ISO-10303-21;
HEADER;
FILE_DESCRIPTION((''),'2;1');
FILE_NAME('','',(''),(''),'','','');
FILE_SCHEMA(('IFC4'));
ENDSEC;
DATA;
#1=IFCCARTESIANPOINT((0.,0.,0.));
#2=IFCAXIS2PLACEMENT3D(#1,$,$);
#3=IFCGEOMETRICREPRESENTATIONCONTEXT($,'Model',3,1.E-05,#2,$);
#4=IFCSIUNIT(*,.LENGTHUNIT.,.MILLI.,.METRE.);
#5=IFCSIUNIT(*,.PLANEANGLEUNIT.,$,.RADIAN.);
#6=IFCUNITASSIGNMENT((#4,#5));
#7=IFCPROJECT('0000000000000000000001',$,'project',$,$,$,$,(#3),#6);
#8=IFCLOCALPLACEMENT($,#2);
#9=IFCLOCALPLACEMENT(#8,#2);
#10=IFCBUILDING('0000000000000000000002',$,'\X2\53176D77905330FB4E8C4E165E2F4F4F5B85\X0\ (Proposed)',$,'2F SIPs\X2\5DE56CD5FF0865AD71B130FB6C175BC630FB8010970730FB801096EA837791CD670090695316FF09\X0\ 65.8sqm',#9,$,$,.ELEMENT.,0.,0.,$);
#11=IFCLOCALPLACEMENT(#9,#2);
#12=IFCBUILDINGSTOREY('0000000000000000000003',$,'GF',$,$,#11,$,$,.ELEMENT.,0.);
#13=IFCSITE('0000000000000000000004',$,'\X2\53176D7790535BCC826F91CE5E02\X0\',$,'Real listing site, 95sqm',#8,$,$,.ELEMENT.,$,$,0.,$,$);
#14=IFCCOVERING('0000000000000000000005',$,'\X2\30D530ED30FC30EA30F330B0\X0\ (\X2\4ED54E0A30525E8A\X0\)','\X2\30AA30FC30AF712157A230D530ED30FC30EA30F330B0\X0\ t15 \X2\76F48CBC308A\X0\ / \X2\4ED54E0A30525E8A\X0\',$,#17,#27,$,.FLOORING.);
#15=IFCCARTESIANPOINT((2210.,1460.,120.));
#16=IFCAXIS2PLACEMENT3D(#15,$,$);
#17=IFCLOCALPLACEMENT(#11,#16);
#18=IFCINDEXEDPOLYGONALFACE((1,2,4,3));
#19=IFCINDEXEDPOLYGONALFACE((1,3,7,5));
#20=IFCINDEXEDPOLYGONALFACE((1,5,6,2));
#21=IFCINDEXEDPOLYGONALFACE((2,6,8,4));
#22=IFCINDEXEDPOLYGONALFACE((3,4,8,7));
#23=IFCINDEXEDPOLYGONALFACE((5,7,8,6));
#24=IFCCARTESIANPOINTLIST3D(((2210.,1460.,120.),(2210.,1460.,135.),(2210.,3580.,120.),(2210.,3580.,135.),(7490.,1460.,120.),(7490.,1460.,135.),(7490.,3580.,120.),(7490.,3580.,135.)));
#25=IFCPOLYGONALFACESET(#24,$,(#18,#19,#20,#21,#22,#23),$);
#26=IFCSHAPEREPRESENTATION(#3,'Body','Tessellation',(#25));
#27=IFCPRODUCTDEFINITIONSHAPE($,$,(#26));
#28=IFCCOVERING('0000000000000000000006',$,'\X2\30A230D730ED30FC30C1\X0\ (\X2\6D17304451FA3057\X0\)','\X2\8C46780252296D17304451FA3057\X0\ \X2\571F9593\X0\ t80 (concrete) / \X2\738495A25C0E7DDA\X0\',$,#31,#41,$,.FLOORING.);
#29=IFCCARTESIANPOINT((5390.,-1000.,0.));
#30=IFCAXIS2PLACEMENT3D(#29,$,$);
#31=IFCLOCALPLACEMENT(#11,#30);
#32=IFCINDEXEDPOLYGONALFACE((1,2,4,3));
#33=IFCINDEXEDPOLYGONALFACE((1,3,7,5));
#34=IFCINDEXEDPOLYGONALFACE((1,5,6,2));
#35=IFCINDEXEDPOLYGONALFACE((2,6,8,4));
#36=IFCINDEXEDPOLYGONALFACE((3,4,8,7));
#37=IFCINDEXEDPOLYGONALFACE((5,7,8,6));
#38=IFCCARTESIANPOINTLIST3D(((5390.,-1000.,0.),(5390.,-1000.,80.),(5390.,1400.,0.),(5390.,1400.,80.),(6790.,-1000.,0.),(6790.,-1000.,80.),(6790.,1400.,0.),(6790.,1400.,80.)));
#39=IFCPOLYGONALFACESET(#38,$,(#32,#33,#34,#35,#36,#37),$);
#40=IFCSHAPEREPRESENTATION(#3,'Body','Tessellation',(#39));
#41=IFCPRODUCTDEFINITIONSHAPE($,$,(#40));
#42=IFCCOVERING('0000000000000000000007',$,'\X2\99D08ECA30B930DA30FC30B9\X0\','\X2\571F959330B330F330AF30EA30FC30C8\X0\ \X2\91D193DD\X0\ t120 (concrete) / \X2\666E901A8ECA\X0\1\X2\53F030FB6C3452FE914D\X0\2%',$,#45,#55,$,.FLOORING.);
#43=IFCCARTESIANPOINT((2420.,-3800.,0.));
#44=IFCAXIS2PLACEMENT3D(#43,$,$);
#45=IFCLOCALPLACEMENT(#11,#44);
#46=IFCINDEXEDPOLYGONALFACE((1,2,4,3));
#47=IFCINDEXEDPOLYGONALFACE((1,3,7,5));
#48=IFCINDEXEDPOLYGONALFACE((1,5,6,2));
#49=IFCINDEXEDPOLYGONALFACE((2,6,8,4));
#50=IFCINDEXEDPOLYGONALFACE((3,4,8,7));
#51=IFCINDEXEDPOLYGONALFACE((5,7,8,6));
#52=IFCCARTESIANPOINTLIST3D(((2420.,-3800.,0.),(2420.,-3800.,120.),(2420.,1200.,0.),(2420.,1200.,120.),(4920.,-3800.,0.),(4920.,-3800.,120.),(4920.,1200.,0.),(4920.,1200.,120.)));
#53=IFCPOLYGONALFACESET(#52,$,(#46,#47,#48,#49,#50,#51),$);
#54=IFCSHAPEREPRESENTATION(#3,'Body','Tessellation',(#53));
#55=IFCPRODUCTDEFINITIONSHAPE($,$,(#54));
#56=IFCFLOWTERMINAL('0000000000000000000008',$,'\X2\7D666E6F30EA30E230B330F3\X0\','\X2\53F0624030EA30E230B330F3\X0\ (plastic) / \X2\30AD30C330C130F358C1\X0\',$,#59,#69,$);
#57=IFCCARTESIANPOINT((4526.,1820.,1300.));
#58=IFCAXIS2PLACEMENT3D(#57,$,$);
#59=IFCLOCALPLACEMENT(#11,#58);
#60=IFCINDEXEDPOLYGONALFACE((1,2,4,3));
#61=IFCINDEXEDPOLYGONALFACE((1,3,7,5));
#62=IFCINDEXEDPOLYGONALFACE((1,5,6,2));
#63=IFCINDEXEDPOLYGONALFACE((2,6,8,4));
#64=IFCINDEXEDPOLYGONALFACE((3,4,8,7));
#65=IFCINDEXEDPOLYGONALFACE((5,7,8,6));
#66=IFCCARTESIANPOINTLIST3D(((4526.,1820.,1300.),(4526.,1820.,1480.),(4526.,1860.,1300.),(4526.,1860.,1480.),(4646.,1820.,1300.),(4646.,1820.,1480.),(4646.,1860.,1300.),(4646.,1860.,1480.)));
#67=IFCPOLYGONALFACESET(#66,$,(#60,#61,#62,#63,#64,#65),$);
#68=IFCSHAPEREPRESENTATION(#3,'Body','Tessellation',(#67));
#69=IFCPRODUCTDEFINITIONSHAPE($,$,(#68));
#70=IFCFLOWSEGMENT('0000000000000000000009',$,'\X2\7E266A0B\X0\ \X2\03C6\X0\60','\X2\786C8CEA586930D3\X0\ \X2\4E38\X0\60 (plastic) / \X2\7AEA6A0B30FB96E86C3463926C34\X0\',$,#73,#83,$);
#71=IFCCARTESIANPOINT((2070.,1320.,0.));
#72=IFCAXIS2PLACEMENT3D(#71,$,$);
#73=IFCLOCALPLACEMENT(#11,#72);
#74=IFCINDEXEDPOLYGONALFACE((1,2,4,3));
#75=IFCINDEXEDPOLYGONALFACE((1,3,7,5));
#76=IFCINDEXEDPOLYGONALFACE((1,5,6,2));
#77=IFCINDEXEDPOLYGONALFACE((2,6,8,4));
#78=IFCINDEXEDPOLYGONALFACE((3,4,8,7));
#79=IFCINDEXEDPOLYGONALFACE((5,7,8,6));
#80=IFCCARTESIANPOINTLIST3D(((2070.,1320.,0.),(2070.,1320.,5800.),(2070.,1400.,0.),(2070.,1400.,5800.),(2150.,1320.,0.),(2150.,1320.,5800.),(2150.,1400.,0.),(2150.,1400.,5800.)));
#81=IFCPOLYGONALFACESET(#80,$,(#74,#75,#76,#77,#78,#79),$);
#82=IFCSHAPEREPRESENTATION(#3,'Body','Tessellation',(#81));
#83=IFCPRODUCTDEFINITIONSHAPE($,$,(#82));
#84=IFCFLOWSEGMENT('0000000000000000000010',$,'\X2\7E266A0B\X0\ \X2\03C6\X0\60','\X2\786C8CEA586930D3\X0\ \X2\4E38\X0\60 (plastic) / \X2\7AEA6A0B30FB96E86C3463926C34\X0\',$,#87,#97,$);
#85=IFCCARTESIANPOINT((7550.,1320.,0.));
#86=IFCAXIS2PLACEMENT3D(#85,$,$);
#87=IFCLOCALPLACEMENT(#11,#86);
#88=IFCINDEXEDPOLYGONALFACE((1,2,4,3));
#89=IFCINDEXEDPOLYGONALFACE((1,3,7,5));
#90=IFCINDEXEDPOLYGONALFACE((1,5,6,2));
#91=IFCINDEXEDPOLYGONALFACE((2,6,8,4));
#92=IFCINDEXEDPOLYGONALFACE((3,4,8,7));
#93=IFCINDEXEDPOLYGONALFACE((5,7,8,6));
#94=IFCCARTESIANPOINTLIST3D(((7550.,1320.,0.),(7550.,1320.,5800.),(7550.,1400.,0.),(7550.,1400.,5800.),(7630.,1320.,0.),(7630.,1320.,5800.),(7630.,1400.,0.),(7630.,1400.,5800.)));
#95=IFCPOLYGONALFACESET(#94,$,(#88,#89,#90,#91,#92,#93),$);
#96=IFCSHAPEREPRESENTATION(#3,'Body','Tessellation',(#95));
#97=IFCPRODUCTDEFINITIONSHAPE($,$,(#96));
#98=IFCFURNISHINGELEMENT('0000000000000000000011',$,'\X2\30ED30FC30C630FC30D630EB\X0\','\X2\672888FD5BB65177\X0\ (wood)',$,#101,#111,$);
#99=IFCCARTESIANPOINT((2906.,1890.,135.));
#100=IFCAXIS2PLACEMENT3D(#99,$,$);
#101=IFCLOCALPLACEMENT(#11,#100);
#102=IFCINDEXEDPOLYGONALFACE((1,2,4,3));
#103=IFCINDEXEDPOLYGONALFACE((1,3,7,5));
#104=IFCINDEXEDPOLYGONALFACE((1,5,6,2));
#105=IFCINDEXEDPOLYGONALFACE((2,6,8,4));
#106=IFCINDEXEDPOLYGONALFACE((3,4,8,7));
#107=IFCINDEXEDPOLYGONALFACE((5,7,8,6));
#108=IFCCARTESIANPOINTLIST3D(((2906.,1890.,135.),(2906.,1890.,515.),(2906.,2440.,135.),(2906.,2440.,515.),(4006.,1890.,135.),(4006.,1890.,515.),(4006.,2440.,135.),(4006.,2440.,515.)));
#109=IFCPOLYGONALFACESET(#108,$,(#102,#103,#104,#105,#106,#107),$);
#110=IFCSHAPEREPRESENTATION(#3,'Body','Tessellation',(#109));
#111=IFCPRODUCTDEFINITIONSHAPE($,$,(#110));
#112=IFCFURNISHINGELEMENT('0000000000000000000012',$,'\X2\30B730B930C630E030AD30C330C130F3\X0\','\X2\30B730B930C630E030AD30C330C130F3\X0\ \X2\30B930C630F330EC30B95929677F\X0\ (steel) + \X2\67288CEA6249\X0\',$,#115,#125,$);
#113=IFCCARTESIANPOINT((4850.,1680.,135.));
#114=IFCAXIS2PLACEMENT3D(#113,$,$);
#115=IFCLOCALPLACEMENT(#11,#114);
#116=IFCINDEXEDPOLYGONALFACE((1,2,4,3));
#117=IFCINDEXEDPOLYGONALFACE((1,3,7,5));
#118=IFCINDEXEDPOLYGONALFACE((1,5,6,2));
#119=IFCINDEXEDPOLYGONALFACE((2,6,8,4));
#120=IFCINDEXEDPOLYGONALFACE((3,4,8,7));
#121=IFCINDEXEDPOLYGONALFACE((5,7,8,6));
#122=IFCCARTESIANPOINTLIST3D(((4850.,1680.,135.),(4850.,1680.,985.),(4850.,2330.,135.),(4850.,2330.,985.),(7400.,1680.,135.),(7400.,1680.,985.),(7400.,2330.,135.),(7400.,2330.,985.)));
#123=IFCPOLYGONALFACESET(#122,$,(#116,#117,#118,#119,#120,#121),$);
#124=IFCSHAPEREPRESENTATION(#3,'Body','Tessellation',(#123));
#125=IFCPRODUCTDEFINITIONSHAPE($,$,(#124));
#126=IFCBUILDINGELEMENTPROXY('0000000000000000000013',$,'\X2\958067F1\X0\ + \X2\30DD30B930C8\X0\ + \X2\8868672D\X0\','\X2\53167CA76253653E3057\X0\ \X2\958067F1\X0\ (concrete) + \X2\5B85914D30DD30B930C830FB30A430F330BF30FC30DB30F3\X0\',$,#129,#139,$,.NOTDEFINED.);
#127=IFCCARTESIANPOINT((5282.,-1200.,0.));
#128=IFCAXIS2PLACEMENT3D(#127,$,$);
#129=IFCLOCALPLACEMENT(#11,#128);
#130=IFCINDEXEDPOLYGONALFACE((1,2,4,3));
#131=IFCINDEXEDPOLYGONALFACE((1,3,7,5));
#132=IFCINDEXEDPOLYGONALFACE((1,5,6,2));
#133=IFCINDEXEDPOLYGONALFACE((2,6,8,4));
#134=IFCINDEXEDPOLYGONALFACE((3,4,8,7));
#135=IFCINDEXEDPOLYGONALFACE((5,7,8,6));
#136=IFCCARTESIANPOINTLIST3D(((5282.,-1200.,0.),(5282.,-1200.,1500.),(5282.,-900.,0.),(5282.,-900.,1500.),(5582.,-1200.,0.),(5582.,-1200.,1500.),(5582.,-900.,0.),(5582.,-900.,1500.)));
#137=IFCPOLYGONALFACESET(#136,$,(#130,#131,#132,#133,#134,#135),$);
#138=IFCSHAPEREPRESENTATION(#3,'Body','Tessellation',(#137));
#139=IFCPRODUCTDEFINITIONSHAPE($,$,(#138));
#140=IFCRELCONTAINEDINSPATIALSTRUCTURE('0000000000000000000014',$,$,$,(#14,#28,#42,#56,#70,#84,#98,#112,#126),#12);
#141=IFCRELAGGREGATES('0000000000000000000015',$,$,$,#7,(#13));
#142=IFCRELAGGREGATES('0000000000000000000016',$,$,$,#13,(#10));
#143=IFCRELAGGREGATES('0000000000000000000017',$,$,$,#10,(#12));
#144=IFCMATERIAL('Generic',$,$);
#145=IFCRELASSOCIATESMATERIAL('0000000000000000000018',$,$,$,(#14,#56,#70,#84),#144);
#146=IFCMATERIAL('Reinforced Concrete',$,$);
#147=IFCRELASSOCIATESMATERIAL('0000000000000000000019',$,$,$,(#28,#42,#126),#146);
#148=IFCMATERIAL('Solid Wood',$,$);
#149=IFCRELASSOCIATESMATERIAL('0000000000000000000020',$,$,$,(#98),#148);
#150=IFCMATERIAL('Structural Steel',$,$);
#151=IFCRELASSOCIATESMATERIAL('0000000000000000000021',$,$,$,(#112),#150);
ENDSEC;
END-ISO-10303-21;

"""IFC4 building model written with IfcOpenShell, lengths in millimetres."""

from ifc_helpers import new_model, si_unit, frame, frame_2d, origin, place, context, project, spatial, rectangle, extrude, material, element, save


model = new_model("IFC4")

# Units and contexts
model_context = context("Model", 3, precision=1e-05, world=origin())
ifc_project = project(units=[si_unit("LENGTHUNIT", "METRE", prefix="MILLI"), si_unit("PLANEANGLEUNIT", "RADIAN")], contexts=[model_context])

# Site, building, storey
site_placement = place(None, origin())
site = spatial("IfcSite", under=ifc_project, at=site_placement, Name="北海道富良野市", ObjectType="Real listing site, 95sqm", CompositionType="ELEMENT", RefElevation=0.0)
building_placement = place(site_placement, origin())
building = spatial("IfcBuilding", under=site, at=building_placement, Name="北海道・二世帯住宅 (Proposed)", ObjectType="2F SIPs工法（断熱・気密・耐震・耐雪荷重最適化） 65.8sqm", CompositionType="ELEMENT", ElevationOfRefHeight=0.0, ElevationOfTerrain=0.0)
storey_placement = place(building_placement, origin())
storey = spatial("IfcBuildingStorey", under=building, at=storey_placement, Name="GF", CompositionType="ELEMENT", Elevation=0.0)

# Shared definitions
ifc_material_1 = material(Name="Solid Wood")

# Shared definitions
ifc_material_2 = material(Name="Reinforced Concrete")

# Coverings
ifc_material_3 = material(Name="Generic")
covering_1_placement = place(storey_placement, frame((2210.0, 1460.0, 120.0)))
element("IfcCovering", 1, at=covering_1_placement, inside=storey, material=ifc_material_3, Name="フローリング (仕上げ床)", Description="オーク無垢フローリング t15 直貼り / 仕上げ床", PredefinedType="FLOORING", context=model_context, shape_type="SweptSolid", body=[
    extrude(rectangle(XDim=5280.0, YDim=2120.0, at=frame_2d((2640.0, 1060.0))), frame((2210.0, 1460.0, 120.0)), (0.0, 0.0, 1.0), 15.0),
])
covering_2_placement = place(storey_placement, frame((5390.0, -1000.0, 0.0)))
element("IfcCovering", 2, at=covering_2_placement, inside=storey, material=ifc_material_2, Name="アプローチ (洗い出し)", Description="豆砂利洗い出し 土間 t80 (concrete) / 玄関導線", PredefinedType="FLOORING", context=model_context, shape_type="SweptSolid", body=[
    extrude(rectangle(XDim=1400.0, YDim=2400.0, at=frame_2d((700.0, 1200.0))), frame((5390.0, -1000.0, 0.0)), (0.0, 0.0, 1.0), 80.0),
])
covering_3_placement = place(storey_placement, frame((2420.0, -3800.0, 0.0)))
element("IfcCovering", 3, at=covering_3_placement, inside=storey, material=ifc_material_2, Name="駐車スペース", Description="土間コンクリート 金鏝 t120 (concrete) / 普通車1台・水勾配2%", PredefinedType="FLOORING", context=model_context, shape_type="SweptSolid", body=[
    extrude(rectangle(XDim=2500.0, YDim=5000.0, at=frame_2d((1250.0, 2500.0))), frame((2420.0, -3800.0, 0.0)), (0.0, 0.0, 1.0), 120.0),
])

# Flow terminal
flow_terminal_placement = place(storey_placement, frame((4526.0, 1820.0, 1300.0)))
element("IfcFlowTerminal", 4, at=flow_terminal_placement, inside=storey, material=ifc_material_3, Name="給湯リモコン", Description="台所リモコン (plastic) / キッチン壁", context=model_context, shape_type="SweptSolid", body=[
    extrude(rectangle(XDim=120.0, YDim=40.0, at=frame_2d((60.0, 20.0))), frame((4526.0, 1820.0, 1300.0)), (0.0, 0.0, 1.0), 180.0),
])

# Flow segments
flow_segment_1_placement = place(storey_placement, frame((2070.0, 1320.0, 0.0)))
element("IfcFlowSegment", 5, at=flow_segment_1_placement, inside=storey, material=ifc_material_3, Name="縦樋 φ60", Description="硬質塩ビ 丸60 (plastic) / 竪樋・雨水排水", context=model_context, shape_type="SweptSolid", body=[
    extrude(rectangle(XDim=80.0, YDim=80.0, at=frame_2d((40.0, 40.0))), frame((2070.0, 1320.0, 0.0)), (0.0, 0.0, 1.0), 5800.0),
])
flow_segment_2_placement = place(storey_placement, frame((7550.0, 1320.0, 0.0)))
element("IfcFlowSegment", 6, at=flow_segment_2_placement, inside=storey, material=ifc_material_3, Name="縦樋 φ60", Description="硬質塩ビ 丸60 (plastic) / 竪樋・雨水排水", context=model_context, shape_type="SweptSolid", body=[
    extrude(rectangle(XDim=80.0, YDim=80.0, at=frame_2d((40.0, 40.0))), frame((7550.0, 1320.0, 0.0)), (0.0, 0.0, 1.0), 5800.0),
])

# Furnishing elements
furnishing_1_placement = place(storey_placement, frame((2906.0, 1890.0, 135.0)))
element("IfcFurnishingElement", 7, at=furnishing_1_placement, inside=storey, material=ifc_material_1, Name="ローテーブル", Description="木製家具 (wood)", context=model_context, shape_type="SweptSolid", body=[
    extrude(rectangle(XDim=1100.0, YDim=550.0, at=frame_2d((550.0, 275.0))), frame((2906.0, 1890.0, 135.0)), (0.0, 0.0, 1.0), 380.0),
])
ifc_material_4 = material(Name="Structural Steel")
furnishing_2_placement = place(storey_placement, frame((4850.0, 1680.0, 135.0)))
element("IfcFurnishingElement", 8, at=furnishing_2_placement, inside=storey, material=ifc_material_4, Name="システムキッチン", Description="システムキッチン ステンレス天板 (steel) + 木質扉", context=model_context, shape_type="SweptSolid", body=[
    extrude(rectangle(XDim=2550.0, YDim=650.0, at=frame_2d((1275.0, 325.0))), frame((4850.0, 1680.0, 135.0)), (0.0, 0.0, 1.0), 850.0),
])

# Building element proxy
proxy_placement = place(storey_placement, frame((5282.0, -1200.0, 0.0)))
element("IfcBuildingElementProxy", 9, at=proxy_placement, inside=storey, material=ifc_material_2, Name="門柱 + ポスト + 表札", Description="化粧打放し 門柱 (concrete) + 宅配ポスト・インターホン", PredefinedType="NOTDEFINED", context=model_context, shape_type="SweptSolid", body=[
    extrude(rectangle(XDim=300.0, YDim=300.0, at=frame_2d((150.0, 150.0))), frame((5282.0, -1200.0, 0.0)), (0.0, 0.0, 1.0), 1500.0),
])

save(model, "model.ifc")
